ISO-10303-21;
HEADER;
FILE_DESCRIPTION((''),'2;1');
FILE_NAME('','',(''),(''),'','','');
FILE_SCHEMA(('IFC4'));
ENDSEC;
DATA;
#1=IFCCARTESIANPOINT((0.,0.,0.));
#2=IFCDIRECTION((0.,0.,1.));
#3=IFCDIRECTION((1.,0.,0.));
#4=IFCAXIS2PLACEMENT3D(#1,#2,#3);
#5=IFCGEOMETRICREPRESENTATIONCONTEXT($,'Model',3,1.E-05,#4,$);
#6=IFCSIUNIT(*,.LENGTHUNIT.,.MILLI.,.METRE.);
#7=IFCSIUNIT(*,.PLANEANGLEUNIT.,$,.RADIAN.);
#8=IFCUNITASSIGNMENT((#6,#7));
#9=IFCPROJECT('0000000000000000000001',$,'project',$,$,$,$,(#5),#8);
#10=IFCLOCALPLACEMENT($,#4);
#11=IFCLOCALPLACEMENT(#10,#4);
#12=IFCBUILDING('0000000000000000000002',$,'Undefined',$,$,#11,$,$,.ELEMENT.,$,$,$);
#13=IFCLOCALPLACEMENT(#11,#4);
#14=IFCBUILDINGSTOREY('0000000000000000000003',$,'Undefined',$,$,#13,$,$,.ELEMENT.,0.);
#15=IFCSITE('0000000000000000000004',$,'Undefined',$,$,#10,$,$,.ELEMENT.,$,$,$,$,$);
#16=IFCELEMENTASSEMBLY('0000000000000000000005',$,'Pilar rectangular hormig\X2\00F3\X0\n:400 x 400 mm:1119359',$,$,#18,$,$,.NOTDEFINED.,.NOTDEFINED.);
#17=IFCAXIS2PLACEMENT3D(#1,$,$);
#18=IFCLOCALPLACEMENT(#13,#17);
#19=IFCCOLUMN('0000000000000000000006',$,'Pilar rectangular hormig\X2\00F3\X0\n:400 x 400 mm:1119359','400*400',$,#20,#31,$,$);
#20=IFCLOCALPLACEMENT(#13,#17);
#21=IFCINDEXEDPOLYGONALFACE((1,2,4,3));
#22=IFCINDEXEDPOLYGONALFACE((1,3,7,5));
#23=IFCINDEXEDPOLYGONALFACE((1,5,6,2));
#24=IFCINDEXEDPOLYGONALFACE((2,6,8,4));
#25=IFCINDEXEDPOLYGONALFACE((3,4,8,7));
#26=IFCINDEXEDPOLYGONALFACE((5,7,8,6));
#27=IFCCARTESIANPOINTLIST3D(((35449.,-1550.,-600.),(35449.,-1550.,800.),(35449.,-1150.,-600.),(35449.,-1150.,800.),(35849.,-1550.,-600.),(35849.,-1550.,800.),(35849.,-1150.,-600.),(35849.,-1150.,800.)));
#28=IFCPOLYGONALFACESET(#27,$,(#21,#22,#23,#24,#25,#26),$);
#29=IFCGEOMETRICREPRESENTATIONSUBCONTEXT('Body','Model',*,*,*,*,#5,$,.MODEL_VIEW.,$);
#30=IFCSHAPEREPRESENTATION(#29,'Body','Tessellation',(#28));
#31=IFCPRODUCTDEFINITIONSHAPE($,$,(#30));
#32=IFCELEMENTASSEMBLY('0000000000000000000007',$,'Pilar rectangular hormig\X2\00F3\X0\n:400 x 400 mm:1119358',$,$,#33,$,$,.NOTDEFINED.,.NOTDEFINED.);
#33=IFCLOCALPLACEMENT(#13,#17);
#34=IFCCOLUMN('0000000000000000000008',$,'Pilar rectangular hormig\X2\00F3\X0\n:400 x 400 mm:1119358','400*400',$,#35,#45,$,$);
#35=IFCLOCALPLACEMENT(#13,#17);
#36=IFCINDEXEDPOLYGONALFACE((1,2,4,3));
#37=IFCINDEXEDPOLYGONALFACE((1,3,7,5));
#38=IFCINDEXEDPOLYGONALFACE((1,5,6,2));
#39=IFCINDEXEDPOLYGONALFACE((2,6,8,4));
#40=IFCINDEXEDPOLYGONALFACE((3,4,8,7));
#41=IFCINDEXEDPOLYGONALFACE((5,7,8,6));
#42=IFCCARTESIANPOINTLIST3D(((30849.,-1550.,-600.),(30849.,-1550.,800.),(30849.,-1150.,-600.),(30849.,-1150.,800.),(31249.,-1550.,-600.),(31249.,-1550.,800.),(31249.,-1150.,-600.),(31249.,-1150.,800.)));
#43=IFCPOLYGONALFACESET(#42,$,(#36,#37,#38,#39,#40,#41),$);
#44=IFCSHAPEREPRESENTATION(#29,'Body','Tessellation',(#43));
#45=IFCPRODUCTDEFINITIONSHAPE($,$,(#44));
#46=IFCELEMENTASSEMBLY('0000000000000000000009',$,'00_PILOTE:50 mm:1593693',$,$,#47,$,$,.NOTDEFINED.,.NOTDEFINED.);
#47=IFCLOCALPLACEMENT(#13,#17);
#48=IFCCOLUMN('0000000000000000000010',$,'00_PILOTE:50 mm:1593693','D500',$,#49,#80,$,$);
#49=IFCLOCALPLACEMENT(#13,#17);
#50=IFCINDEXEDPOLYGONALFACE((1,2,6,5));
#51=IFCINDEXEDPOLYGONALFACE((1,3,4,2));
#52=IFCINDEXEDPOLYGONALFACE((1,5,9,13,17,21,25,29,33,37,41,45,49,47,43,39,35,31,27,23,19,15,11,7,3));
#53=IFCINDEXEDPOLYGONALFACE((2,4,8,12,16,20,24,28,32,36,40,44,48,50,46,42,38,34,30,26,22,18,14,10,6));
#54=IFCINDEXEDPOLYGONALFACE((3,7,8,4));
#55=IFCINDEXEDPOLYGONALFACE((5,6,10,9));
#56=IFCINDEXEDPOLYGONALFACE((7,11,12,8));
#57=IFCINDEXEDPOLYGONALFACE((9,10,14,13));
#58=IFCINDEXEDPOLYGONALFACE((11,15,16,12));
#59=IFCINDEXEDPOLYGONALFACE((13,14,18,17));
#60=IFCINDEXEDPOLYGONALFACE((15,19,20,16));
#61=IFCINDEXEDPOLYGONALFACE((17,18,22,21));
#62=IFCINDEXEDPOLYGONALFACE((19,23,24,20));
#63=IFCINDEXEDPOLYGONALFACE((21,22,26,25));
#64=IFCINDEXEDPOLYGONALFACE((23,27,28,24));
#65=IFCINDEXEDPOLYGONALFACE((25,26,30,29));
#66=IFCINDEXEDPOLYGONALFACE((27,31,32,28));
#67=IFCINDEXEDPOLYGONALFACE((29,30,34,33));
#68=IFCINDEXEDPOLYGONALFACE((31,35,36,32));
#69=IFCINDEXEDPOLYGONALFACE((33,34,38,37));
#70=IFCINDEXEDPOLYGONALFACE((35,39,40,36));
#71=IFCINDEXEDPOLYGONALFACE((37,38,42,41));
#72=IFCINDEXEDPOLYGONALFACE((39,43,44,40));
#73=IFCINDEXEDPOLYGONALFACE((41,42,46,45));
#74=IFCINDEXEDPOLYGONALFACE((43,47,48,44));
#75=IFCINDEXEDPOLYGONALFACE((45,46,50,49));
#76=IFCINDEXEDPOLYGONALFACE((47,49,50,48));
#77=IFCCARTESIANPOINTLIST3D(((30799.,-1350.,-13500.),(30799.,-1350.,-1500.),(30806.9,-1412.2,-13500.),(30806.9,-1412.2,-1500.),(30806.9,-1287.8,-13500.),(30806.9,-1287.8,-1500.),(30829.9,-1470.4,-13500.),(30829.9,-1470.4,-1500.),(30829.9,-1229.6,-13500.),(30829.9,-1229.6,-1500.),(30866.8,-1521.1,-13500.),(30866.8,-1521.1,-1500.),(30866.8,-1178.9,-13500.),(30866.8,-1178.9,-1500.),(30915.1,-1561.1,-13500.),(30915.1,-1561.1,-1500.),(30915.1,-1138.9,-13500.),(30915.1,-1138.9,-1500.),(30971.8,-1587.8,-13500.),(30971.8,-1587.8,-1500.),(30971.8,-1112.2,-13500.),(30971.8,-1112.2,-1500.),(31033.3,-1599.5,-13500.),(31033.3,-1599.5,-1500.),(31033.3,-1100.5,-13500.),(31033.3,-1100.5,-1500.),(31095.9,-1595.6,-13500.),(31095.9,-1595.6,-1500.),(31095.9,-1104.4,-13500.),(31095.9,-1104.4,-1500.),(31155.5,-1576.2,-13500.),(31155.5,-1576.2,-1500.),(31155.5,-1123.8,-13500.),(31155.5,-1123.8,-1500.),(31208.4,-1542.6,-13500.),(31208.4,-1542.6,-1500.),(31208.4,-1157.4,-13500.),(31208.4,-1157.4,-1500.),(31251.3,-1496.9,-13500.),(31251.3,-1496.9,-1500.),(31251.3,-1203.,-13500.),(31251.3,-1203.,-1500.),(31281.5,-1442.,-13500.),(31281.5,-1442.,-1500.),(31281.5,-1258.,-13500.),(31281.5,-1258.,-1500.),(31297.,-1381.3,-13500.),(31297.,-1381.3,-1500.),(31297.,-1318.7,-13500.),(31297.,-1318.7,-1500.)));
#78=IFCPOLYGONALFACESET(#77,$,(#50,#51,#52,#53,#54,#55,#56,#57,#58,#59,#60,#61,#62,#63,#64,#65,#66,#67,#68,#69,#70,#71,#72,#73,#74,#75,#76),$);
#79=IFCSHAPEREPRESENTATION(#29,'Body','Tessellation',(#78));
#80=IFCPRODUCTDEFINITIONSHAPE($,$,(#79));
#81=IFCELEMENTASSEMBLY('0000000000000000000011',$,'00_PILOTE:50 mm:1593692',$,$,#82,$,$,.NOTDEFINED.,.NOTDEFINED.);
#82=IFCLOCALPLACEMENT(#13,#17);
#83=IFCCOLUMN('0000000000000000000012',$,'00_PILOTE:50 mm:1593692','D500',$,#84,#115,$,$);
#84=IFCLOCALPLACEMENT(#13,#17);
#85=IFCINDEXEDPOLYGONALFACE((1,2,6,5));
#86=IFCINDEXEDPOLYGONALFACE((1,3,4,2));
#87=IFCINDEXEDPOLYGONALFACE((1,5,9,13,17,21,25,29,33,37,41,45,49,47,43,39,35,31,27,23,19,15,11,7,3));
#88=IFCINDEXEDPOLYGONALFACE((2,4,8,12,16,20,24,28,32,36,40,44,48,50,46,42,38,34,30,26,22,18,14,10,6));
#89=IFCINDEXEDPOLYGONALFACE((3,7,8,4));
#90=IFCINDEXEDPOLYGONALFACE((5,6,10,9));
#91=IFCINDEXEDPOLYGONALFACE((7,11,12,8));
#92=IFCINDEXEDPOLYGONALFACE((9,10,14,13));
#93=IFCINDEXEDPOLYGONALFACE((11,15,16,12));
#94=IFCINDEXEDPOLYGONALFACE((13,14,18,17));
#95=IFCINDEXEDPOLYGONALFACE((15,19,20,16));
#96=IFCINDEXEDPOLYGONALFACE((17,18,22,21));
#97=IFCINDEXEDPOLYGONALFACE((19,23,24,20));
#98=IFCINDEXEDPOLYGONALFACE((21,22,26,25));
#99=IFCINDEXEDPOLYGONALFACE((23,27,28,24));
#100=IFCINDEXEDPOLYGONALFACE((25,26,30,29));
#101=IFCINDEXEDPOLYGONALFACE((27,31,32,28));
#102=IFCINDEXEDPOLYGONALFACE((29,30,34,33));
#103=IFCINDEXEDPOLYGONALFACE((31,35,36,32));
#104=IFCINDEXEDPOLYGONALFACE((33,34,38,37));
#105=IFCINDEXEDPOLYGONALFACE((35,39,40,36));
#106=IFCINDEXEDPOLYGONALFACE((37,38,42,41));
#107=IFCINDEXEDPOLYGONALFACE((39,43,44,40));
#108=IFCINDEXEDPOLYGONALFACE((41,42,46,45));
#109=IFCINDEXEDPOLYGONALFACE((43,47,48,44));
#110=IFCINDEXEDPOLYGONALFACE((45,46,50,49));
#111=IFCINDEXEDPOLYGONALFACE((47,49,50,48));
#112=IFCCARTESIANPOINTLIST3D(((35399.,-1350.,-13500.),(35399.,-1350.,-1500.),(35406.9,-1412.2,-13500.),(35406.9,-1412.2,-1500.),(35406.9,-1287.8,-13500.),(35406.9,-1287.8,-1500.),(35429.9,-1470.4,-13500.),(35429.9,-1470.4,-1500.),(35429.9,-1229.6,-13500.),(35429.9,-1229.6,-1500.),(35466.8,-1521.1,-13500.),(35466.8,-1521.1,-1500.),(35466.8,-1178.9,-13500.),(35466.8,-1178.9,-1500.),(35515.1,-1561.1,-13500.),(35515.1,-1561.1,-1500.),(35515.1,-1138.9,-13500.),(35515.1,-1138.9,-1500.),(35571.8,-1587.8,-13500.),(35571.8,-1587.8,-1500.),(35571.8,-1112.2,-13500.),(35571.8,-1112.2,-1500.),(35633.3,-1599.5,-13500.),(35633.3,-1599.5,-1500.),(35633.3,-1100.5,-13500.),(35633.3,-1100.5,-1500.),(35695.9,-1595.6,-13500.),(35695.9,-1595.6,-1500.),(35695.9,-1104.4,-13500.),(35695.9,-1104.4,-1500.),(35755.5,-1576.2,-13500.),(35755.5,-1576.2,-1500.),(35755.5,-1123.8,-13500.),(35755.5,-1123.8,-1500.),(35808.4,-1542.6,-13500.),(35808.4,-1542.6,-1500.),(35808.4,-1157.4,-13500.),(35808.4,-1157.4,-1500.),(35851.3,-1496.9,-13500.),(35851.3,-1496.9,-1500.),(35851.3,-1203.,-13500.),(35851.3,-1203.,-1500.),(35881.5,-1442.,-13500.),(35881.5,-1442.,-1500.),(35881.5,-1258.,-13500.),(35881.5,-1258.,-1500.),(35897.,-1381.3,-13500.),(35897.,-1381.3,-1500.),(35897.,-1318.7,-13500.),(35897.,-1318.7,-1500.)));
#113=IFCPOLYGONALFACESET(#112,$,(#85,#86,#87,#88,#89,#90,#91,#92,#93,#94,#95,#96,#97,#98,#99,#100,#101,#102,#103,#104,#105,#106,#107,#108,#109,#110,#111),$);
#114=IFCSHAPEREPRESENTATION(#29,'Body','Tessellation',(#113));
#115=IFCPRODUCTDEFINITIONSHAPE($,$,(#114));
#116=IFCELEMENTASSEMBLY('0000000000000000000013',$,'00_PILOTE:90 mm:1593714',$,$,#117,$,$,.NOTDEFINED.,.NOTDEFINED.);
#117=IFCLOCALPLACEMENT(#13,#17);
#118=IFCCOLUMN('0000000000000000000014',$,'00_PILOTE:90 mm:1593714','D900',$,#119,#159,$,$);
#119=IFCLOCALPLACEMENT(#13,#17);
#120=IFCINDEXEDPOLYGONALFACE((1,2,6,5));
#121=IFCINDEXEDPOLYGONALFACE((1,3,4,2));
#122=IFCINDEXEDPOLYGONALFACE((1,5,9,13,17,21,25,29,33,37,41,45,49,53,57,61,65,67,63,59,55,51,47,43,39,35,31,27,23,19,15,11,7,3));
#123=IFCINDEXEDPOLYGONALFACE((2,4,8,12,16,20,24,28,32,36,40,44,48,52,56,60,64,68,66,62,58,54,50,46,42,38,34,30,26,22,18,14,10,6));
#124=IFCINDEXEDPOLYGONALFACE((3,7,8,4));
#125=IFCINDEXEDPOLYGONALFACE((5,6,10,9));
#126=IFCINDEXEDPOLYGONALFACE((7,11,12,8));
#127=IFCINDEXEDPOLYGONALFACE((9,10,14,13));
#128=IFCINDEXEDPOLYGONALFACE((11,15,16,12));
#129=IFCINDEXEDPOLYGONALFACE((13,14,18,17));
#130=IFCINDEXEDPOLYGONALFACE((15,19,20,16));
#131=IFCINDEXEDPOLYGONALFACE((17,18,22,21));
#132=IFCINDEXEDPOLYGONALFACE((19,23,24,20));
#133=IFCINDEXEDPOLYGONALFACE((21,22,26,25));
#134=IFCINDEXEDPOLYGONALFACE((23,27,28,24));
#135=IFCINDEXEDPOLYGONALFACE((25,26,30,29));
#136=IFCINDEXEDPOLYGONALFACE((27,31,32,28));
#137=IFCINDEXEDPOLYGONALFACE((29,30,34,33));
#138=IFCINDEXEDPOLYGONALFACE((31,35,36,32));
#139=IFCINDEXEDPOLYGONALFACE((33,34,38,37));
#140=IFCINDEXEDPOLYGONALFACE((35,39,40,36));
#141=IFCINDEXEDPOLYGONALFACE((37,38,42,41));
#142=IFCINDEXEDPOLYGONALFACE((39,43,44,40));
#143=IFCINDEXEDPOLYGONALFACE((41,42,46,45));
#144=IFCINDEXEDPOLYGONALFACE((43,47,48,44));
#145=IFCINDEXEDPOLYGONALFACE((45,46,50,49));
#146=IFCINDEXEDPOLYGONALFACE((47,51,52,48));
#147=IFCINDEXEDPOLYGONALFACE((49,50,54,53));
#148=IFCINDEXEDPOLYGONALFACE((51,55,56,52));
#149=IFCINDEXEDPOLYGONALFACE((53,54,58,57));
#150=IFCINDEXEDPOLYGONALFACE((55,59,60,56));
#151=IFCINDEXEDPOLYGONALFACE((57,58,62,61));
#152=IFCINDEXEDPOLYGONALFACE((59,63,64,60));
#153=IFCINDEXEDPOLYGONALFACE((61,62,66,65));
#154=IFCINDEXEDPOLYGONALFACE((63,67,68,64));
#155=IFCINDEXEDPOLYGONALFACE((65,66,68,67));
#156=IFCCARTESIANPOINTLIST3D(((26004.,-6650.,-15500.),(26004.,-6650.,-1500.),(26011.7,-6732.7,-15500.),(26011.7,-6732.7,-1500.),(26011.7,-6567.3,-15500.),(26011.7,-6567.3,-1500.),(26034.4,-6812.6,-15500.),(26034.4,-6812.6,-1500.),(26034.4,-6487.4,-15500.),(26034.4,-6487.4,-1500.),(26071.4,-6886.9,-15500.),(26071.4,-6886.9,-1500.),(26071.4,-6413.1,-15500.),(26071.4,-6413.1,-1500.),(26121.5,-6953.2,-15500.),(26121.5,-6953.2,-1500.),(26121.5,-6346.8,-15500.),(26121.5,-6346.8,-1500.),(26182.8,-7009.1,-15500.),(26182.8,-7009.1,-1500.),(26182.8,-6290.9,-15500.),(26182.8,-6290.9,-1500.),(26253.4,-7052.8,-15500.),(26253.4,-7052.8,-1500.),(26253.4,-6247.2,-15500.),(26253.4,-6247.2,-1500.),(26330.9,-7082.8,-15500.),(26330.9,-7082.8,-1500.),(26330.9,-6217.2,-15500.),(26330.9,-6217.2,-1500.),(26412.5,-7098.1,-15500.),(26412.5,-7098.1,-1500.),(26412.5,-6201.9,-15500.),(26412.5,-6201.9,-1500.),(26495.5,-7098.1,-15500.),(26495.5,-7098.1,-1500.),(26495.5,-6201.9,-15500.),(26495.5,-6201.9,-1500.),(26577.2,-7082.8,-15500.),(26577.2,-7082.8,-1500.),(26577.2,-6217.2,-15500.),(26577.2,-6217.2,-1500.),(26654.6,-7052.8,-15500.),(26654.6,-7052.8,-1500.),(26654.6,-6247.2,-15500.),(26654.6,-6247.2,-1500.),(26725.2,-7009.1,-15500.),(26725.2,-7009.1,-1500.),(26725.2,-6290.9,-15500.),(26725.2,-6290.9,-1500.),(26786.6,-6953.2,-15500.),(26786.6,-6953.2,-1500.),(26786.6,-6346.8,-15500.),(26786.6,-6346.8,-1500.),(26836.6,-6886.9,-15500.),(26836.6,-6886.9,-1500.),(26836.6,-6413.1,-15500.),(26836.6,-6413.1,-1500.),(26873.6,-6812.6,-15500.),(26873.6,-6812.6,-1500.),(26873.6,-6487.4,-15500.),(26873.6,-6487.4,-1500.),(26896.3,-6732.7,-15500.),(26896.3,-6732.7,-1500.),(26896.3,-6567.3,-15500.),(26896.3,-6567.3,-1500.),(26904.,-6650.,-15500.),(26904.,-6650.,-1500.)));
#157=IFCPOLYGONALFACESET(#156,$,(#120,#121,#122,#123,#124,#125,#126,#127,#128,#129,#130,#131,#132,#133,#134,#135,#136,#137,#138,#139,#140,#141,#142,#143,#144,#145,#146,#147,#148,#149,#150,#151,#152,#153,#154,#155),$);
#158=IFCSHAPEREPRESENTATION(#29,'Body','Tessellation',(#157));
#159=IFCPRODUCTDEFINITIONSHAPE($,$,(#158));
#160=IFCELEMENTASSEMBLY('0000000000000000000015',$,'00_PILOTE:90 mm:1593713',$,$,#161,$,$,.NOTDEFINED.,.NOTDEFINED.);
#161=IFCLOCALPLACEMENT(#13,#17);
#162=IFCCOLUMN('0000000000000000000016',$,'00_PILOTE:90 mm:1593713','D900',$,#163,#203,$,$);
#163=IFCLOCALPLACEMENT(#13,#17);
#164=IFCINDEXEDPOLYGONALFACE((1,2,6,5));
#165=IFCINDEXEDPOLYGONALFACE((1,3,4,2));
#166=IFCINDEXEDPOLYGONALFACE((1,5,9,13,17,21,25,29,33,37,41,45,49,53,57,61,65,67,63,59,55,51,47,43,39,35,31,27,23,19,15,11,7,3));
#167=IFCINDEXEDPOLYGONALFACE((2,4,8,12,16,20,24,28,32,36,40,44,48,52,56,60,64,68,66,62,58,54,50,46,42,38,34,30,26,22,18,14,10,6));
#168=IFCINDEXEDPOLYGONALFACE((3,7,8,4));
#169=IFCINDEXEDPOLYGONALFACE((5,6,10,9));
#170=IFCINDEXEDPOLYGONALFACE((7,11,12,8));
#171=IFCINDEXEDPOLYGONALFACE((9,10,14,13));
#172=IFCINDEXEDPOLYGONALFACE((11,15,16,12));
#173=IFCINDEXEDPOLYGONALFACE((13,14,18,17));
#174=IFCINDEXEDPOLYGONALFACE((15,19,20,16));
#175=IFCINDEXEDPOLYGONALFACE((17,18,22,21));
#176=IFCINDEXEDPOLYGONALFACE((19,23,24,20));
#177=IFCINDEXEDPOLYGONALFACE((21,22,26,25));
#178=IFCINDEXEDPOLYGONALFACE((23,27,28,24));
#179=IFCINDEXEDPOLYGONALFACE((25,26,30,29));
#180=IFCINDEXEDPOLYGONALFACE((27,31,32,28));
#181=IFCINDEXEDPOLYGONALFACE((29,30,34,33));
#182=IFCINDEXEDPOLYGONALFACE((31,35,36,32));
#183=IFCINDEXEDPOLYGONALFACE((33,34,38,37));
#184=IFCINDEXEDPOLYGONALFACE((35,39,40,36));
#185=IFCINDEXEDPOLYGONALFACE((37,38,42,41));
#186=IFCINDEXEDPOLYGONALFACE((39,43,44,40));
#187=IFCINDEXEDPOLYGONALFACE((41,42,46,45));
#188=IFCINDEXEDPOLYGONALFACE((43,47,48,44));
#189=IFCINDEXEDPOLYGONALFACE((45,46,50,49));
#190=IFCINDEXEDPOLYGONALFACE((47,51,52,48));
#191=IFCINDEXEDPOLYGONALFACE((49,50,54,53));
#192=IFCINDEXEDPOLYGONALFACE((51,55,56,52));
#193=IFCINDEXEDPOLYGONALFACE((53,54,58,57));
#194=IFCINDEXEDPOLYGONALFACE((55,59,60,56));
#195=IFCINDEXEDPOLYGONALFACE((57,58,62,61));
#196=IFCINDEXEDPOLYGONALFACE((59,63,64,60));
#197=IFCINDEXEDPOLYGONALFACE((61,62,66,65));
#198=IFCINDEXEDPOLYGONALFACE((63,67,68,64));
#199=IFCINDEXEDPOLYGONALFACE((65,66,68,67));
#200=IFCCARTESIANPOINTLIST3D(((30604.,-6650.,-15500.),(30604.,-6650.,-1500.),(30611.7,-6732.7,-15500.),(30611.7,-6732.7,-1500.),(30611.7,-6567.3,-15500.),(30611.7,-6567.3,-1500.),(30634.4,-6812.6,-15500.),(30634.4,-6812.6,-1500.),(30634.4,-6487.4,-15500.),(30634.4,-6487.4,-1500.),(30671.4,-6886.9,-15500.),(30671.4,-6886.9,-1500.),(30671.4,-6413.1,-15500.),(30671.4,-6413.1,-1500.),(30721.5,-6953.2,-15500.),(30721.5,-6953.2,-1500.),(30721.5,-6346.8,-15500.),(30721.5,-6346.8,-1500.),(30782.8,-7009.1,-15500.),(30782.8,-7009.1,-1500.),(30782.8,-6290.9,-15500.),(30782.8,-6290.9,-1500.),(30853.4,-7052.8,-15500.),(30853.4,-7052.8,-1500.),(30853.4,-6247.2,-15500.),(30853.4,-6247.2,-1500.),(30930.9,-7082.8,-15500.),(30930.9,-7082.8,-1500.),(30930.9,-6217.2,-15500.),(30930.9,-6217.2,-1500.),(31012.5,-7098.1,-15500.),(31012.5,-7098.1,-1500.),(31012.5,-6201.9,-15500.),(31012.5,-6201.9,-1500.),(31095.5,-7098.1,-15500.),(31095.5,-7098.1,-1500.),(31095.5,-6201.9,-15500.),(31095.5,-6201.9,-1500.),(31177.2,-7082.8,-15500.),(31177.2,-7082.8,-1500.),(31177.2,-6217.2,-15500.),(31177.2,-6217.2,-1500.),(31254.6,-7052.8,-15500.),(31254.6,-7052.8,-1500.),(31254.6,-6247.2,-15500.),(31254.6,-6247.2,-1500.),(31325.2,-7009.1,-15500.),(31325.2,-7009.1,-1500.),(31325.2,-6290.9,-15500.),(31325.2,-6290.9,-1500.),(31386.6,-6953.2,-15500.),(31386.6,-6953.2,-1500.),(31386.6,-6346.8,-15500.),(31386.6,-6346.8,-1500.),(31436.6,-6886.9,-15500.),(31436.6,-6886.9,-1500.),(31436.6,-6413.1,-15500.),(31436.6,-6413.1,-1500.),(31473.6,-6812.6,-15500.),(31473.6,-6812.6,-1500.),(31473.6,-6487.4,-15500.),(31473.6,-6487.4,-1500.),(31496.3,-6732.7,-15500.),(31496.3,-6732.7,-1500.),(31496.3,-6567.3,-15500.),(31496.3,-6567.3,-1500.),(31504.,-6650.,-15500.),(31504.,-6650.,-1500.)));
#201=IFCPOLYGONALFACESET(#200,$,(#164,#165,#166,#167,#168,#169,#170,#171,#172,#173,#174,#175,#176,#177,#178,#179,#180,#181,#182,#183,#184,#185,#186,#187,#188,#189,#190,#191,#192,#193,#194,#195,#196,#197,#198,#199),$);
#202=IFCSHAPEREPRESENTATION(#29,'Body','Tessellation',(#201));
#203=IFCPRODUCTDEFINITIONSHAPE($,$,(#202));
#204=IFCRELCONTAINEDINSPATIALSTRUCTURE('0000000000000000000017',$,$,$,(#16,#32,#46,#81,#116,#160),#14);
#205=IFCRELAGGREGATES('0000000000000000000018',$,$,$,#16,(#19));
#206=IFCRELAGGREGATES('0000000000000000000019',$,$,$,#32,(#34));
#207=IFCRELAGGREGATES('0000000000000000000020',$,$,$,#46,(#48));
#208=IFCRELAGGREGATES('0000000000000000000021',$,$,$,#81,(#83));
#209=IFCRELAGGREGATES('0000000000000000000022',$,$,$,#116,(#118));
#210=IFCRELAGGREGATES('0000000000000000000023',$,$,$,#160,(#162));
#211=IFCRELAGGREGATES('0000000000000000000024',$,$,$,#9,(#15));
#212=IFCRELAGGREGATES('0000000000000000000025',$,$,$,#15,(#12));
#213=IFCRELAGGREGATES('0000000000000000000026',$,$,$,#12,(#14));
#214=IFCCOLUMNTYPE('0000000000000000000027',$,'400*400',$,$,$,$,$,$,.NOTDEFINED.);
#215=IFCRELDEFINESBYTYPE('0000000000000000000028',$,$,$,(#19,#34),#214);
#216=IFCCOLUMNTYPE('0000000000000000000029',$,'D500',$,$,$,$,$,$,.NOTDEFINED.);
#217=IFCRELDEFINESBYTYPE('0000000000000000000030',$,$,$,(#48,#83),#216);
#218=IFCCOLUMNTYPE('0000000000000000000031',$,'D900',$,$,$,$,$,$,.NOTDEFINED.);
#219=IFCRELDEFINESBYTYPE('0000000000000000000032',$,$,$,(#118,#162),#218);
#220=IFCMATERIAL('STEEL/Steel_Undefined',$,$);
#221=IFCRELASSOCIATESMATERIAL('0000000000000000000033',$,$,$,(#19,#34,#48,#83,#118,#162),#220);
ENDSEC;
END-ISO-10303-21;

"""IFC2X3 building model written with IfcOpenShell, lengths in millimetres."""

from ifc_helpers import new_model, si_unit, frame, origin_with_axes, origin_2d_with_axis, place, context, subcontext, project, spatial, rectangle, circle, extrude, material, type_object, element, aggregate, save


model = new_model("IFC2X3")

# Units and contexts
model_context = context("Model", 3, precision=1e-05, world=origin_with_axes())
body_context = subcontext(model_context, "Body", "Model", "MODEL_VIEW")
ifc_project = project(units=[si_unit("LENGTHUNIT", "METRE", prefix="MILLI"), si_unit("PLANEANGLEUNIT", "RADIAN")], contexts=[model_context])

# Site, building, storey
site_placement = place(None, origin_with_axes())
site = spatial("IfcSite", under=ifc_project, at=site_placement, Name="Undefined", CompositionType="ELEMENT")
building_placement = place(site_placement, origin_with_axes())
building = spatial("IfcBuilding", under=site, at=building_placement, Name="Undefined", CompositionType="ELEMENT")
storey_placement = place(building_placement, origin_with_axes())
storey = spatial("IfcBuildingStorey", under=building, at=storey_placement, Name="Undefined", CompositionType="ELEMENT", Elevation=0.0)

# Element assemblies, columns
ifc_material_1 = material(Name="STEEL/Steel_Undefined")
assembly_1_placement = place(storey_placement, origin_with_axes())
assembly_1 = element("IfcElementAssembly", 1, at=assembly_1_placement, inside=storey, Name="Pilar rectangular hormigón:400 x 400 mm:1119359", AssemblyPlace="NOTDEFINED", PredefinedType="NOTDEFINED")
column_type_1 = type_object("IfcColumnType", Name="400*400", PredefinedType="NOTDEFINED")
column_1_placement = place(assembly_1_placement, frame((35649.0, -1350.0, -600.0), z_axis=(0.0, 0.0, 1.0), x_axis=(0.0, 1.0, 0.0)))
column_1 = element("IfcColumn", 2, at=column_1_placement, type_object=column_type_1, material=ifc_material_1, Name="Pilar rectangular hormigón:400 x 400 mm:1119359", Description="400*400", context=body_context, shape_type="SweptSolid", body=[
    extrude(rectangle(XDim=400.0, YDim=400.0, at=origin_2d_with_axis()), frame((0.0, 0.0, 1400.0), z_axis=(0.0, 0.0, -1.0), x_axis=(0.0, 1.0, 0.0)), (0.0, 0.0, 1.0), 1400.0),
])
aggregate(assembly_1, [column_1])
assembly_2_placement = place(storey_placement, origin_with_axes())
assembly_2 = element("IfcElementAssembly", 3, at=assembly_2_placement, inside=storey, Name="Pilar rectangular hormigón:400 x 400 mm:1119358", AssemblyPlace="NOTDEFINED", PredefinedType="NOTDEFINED")
column_2_placement = place(assembly_2_placement, frame((31049.0, -1350.0, -600.0), z_axis=(0.0, 0.0, 1.0), x_axis=(0.0, 1.0, 0.0)))
column_2 = element("IfcColumn", 4, at=column_2_placement, type_object=column_type_1, material=ifc_material_1, Name="Pilar rectangular hormigón:400 x 400 mm:1119358", Description="400*400", context=body_context, shape_type="SweptSolid", body=[
    extrude(rectangle(XDim=400.0, YDim=400.0, at=origin_2d_with_axis()), frame((0.0, 0.0, 1400.0), z_axis=(0.0, 0.0, -1.0), x_axis=(0.0, 1.0, 0.0)), (0.0, 0.0, 1.0), 1400.0),
])
aggregate(assembly_2, [column_2])
assembly_3_placement = place(storey_placement, origin_with_axes())
assembly_3 = element("IfcElementAssembly", 5, at=assembly_3_placement, inside=storey, Name="00_PILOTE:50 mm:1593693", AssemblyPlace="NOTDEFINED", PredefinedType="NOTDEFINED")
column_type_2 = type_object("IfcColumnType", Name="D500", PredefinedType="NOTDEFINED")
column_3_placement = place(assembly_3_placement, frame((31049.0, -1350.0, -13500.0), z_axis=(0.0, 0.0, 1.0), x_axis=(0.0, 1.0, 0.0)))
column_3 = element("IfcColumn", 6, at=column_3_placement, type_object=column_type_2, material=ifc_material_1, Name="00_PILOTE:50 mm:1593693", Description="D500", context=body_context, shape_type="SweptSolid", body=[
    extrude(circle(Radius=250.0, at=origin_2d_with_axis()), frame((0.0, 0.0, 12000.0), z_axis=(0.0, 0.0, -1.0), x_axis=(0.0, 1.0, 0.0)), (0.0, 0.0, 1.0), 12000.0),
])
aggregate(assembly_3, [column_3])
assembly_4_placement = place(storey_placement, origin_with_axes())
assembly_4 = element("IfcElementAssembly", 7, at=assembly_4_placement, inside=storey, Name="00_PILOTE:50 mm:1593692", AssemblyPlace="NOTDEFINED", PredefinedType="NOTDEFINED")
column_4_placement = place(assembly_4_placement, frame((35649.0, -1350.0, -13500.0), z_axis=(0.0, 0.0, 1.0), x_axis=(0.0, 1.0, 0.0)))
column_4 = element("IfcColumn", 8, at=column_4_placement, type_object=column_type_2, material=ifc_material_1, Name="00_PILOTE:50 mm:1593692", Description="D500", context=body_context, shape_type="SweptSolid", body=[
    extrude(circle(Radius=250.0, at=origin_2d_with_axis()), frame((0.0, 0.0, 12000.0), z_axis=(0.0, 0.0, -1.0), x_axis=(0.0, 1.0, 0.0)), (0.0, 0.0, 1.0), 12000.0),
])
aggregate(assembly_4, [column_4])
assembly_5_placement = place(storey_placement, origin_with_axes())
assembly_5 = element("IfcElementAssembly", 9, at=assembly_5_placement, inside=storey, Name="00_PILOTE:90 mm:1593714", AssemblyPlace="NOTDEFINED", PredefinedType="NOTDEFINED")
column_type_3 = type_object("IfcColumnType", Name="D900", PredefinedType="NOTDEFINED")
column_5_placement = place(assembly_5_placement, frame((26454.0, -6650.0, -15500.0), z_axis=(0.0, 0.0, 1.0), x_axis=(0.0, 1.0, 0.0)))
column_5 = element("IfcColumn", 10, at=column_5_placement, type_object=column_type_3, material=ifc_material_1, Name="00_PILOTE:90 mm:1593714", Description="D900", context=body_context, shape_type="SweptSolid", body=[
    extrude(circle(Radius=450.0, at=origin_2d_with_axis()), frame((0.0, 0.0, 14000.0), z_axis=(0.0, 0.0, -1.0), x_axis=(0.0, 1.0, 0.0)), (0.0, 0.0, 1.0), 14000.0),
])
aggregate(assembly_5, [column_5])
assembly_6_placement = place(storey_placement, origin_with_axes())
assembly_6 = element("IfcElementAssembly", 11, at=assembly_6_placement, inside=storey, Name="00_PILOTE:90 mm:1593713", AssemblyPlace="NOTDEFINED", PredefinedType="NOTDEFINED")
column_6_placement = place(assembly_6_placement, frame((31054.0, -6650.0, -15500.0), z_axis=(0.0, 0.0, 1.0), x_axis=(0.0, 1.0, 0.0)))
column_6 = element("IfcColumn", 12, at=column_6_placement, type_object=column_type_3, material=ifc_material_1, Name="00_PILOTE:90 mm:1593713", Description="D900", context=body_context, shape_type="SweptSolid", body=[
    extrude(circle(Radius=450.0, at=origin_2d_with_axis()), frame((0.0, 0.0, 14000.0), z_axis=(0.0, 0.0, -1.0), x_axis=(0.0, 1.0, 0.0)), (0.0, 0.0, 1.0), 14000.0),
])
aggregate(assembly_6, [column_6])

save(model, "model.ifc")
